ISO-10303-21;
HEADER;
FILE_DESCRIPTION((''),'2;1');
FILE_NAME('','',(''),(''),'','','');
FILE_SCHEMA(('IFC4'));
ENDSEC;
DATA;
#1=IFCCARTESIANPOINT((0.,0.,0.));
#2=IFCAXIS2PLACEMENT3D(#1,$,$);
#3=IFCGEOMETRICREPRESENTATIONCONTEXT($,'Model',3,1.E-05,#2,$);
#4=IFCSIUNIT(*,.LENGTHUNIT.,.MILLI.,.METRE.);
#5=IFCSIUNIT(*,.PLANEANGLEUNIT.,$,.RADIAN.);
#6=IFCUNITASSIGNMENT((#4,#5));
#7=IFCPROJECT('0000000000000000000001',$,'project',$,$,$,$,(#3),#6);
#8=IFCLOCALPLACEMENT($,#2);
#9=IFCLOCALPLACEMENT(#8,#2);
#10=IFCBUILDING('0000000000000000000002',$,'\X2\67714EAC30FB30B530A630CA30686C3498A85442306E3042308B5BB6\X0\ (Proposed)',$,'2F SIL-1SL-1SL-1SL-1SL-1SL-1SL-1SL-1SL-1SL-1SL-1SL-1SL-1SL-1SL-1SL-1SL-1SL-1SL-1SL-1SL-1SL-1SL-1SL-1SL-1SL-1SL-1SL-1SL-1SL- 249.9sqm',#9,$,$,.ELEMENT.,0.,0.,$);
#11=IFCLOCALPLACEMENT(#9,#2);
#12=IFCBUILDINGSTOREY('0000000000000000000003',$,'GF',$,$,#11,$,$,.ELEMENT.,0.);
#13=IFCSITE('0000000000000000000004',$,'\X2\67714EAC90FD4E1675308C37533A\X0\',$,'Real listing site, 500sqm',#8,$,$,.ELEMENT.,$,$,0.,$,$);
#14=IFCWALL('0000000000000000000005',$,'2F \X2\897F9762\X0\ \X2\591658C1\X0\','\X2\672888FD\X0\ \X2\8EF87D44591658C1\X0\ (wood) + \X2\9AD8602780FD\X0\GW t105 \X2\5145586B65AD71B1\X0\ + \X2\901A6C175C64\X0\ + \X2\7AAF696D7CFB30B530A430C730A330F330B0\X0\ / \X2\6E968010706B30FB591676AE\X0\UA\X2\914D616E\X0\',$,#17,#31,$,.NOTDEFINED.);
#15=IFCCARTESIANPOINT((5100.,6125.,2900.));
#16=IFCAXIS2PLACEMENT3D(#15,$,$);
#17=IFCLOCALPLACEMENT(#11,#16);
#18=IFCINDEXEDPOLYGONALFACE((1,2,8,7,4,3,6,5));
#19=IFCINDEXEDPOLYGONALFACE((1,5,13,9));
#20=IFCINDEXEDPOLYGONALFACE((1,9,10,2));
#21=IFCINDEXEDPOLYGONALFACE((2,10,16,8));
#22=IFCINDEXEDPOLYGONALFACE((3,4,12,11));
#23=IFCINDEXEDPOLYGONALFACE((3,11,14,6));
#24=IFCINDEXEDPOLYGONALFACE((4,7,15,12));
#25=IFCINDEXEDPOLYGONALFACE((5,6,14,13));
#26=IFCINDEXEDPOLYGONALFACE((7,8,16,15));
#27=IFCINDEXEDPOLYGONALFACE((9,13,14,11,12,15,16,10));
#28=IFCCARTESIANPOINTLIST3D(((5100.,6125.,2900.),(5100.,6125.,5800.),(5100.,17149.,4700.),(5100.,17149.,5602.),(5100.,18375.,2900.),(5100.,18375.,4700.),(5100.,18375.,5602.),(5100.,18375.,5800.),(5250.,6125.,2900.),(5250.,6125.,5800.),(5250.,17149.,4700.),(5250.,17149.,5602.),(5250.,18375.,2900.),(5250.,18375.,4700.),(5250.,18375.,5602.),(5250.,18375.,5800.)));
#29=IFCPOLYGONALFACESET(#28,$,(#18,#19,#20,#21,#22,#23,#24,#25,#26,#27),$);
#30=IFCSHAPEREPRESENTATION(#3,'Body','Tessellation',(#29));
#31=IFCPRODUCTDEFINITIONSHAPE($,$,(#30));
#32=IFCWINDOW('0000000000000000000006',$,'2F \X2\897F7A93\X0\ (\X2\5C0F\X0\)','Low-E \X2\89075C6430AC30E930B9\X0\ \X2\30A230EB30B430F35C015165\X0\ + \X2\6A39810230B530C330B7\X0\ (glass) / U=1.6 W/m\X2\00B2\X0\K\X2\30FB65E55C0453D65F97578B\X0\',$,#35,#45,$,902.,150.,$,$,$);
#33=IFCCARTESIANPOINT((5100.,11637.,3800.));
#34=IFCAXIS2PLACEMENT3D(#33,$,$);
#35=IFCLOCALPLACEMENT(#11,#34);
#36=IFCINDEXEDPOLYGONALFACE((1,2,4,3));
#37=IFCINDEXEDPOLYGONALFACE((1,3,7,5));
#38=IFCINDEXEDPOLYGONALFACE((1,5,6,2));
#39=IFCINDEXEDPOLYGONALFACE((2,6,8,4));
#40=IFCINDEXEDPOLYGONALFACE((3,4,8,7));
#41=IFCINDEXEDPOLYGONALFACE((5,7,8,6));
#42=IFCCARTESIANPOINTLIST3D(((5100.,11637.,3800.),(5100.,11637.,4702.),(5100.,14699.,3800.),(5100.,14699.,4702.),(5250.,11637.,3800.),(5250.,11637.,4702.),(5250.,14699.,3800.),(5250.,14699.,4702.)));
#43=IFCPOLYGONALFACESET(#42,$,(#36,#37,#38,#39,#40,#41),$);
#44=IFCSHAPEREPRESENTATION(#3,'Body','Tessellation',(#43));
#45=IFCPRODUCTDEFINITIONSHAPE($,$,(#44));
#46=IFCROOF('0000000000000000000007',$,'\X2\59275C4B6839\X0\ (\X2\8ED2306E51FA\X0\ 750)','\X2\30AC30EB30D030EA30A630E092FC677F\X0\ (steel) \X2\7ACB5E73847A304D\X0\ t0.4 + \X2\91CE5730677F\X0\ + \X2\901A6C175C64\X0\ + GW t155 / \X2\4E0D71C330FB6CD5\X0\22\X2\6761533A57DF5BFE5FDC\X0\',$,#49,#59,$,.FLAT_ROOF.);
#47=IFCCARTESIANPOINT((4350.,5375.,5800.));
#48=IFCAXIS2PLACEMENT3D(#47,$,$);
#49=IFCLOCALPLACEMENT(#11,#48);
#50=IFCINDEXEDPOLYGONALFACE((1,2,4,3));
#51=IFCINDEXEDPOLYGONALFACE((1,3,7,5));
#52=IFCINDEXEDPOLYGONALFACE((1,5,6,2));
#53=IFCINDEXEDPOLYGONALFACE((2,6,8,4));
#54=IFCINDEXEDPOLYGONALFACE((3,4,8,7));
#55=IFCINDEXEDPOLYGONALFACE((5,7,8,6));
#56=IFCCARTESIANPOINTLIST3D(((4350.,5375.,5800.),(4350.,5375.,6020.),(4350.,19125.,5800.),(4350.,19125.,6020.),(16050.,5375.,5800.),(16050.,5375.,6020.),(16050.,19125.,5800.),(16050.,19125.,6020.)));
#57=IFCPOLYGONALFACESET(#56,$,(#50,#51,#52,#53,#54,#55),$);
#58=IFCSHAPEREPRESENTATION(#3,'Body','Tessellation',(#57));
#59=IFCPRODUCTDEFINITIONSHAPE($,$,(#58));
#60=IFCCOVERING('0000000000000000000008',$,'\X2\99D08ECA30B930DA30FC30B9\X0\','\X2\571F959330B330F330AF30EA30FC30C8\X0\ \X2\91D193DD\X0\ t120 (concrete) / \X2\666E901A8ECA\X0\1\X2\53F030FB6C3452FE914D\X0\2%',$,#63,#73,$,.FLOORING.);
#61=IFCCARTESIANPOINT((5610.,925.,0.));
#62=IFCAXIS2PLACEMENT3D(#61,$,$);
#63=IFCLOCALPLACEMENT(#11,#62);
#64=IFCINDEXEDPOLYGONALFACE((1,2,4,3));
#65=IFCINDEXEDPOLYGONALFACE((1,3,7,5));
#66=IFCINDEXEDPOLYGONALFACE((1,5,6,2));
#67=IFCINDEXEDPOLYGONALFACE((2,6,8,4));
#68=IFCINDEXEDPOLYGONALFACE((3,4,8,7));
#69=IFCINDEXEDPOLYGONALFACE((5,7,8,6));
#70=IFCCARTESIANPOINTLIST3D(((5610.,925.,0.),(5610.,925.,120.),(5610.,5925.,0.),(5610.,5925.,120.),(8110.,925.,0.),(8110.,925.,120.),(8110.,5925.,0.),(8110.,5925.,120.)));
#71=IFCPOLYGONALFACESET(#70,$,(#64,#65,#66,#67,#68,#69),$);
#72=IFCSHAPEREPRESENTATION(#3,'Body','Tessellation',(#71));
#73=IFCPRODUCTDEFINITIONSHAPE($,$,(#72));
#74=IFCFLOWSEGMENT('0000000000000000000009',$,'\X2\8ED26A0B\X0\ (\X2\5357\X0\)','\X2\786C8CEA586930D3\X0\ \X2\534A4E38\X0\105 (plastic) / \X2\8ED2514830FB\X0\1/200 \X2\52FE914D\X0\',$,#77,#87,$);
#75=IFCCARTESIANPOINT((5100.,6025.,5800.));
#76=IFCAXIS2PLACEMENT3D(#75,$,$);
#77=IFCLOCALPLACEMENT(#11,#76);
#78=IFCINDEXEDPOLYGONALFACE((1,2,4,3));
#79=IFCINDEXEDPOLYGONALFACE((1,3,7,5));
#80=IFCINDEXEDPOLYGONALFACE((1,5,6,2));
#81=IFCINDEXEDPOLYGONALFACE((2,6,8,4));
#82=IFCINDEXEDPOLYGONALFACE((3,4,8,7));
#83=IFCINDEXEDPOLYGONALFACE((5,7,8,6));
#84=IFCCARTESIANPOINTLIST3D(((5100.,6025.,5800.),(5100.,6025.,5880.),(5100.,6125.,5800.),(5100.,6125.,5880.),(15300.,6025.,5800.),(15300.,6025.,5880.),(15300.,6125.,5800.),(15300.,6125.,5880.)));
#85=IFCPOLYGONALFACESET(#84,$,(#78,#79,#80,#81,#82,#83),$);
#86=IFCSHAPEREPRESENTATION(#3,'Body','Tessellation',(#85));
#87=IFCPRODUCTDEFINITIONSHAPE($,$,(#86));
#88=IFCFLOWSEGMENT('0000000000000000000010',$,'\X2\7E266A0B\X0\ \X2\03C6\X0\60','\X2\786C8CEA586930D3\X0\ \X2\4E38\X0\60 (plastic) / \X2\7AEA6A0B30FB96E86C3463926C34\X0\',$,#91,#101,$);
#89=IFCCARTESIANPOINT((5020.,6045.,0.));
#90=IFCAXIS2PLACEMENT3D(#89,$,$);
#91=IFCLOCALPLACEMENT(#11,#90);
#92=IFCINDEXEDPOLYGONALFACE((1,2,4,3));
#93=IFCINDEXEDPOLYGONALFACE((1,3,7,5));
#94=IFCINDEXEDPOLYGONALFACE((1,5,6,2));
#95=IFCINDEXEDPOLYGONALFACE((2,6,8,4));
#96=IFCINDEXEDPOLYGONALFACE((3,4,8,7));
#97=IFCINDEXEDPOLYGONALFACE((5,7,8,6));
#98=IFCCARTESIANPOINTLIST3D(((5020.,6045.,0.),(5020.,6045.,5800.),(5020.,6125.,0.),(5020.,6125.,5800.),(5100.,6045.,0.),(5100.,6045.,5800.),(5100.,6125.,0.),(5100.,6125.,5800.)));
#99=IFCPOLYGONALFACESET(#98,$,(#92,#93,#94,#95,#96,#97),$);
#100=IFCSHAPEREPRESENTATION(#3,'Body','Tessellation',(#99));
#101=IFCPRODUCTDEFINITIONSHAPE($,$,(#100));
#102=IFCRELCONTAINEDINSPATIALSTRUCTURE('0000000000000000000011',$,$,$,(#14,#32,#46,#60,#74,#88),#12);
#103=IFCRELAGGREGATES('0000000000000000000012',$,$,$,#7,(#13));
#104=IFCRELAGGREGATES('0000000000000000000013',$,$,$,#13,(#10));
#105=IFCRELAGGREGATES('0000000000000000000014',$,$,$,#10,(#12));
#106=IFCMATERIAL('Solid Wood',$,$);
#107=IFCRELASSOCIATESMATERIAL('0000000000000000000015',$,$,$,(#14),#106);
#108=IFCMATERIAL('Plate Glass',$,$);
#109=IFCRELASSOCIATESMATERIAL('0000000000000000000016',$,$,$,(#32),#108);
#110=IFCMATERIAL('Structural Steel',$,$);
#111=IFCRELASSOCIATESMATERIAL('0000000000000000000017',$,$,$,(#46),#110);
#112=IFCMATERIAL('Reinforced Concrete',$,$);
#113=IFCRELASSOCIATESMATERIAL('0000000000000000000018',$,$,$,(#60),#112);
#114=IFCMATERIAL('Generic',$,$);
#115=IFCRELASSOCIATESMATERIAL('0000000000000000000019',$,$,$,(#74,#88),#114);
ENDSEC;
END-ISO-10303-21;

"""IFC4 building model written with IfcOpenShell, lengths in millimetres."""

from ifc_helpers import new_model, si_unit, frame, frame_2d, origin, place, context, project, spatial, rectangle, extrude, material, element, fill, save


model = new_model("IFC4")

# Units and contexts
model_context = context("Model", 3, precision=1e-05, world=origin())
ifc_project = project(units=[si_unit("LENGTHUNIT", "METRE", prefix="MILLI"), si_unit("PLANEANGLEUNIT", "RADIAN")], contexts=[model_context])

# Site, building, storey
site_placement = place(None, origin())
site = spatial("IfcSite", under=ifc_project, at=site_placement, Name="東京都世田谷区", ObjectType="Real listing site, 500sqm", CompositionType="ELEMENT", RefElevation=0.0)
building_placement = place(site_placement, origin())
building = spatial("IfcBuilding", under=site, at=building_placement, Name="東京・サウナと水風呂のある家 (Proposed)", ObjectType="2F SIL-1SL-1SL-1SL-1SL-1SL-1SL-1SL-1SL-1SL-1SL-1SL-1SL-1SL-1SL-1SL-1SL-1SL-1SL-1SL-1SL-1SL-1SL-1SL-1SL-1SL-1SL-1SL-1SL-1SL- 249.9sqm", CompositionType="ELEMENT", ElevationOfRefHeight=0.0, ElevationOfTerrain=0.0)
storey_placement = place(building_placement, origin())
storey = spatial("IfcBuildingStorey", under=building, at=storey_placement, Name="GF", CompositionType="ELEMENT", Elevation=0.0)

# Shared definitions
ifc_material_1 = material(Name="Solid Wood")

# Shared definitions
ifc_material_2 = material(Name="Reinforced Concrete")

# Shared definitions
ifc_material_3 = material(Name="Plate Glass")

# Wall, opening, window
wall_1_placement = place(storey_placement, frame((5100.0, 6125.0, 2900.0)))
wall_1 = element("IfcWall", 1, at=wall_1_placement, inside=storey, material=ifc_material_1, Name="2F 西面 外壁", Description="木製 軸組外壁 (wood) + 高性能GW t105 充填断熱 + 通気層 + 窯業系サイディング / 準耐火・外皮UA配慮", PredefinedType="NOTDEFINED", context=model_context, shape_type="SweptSolid", body=[
    extrude(rectangle(XDim=150.0, YDim=12250.0, at=frame_2d((75.0, 6125.0))), frame((5100.0, 6125.0, 2900.0)), (0.0, 0.0, 1.0), 2900.0),
])
opening_1_placement = place(storey_placement, frame((5100.0, 11637.0, 3800.0)))
opening_1 = element("IfcOpeningElement", 2, at=opening_1_placement, cuts=wall_1, PredefinedType="NOTDEFINED", context=model_context, shape_type="SweptSolid", body=[
    extrude(rectangle(XDim=150.0, YDim=3062.0, at=frame_2d((75.0, 1531.0))), frame((5100.0, 11637.0, 3800.0)), (0.0, 0.0, 1.0), 902.0),
])
window_1_placement = place(storey_placement, frame((5100.0, 11637.0, 3800.0)))
window_1 = element("IfcWindow", 3, at=window_1_placement, inside=storey, material=ifc_material_3, Name="2F 西窓 (小)", Description="Low-E 複層ガラス アルゴン封入 + 樹脂サッシ (glass) / U=1.6 W/m²K・日射取得型", OverallHeight=902.0, OverallWidth=150.0, context=model_context, shape_type="SweptSolid", body=[
    extrude(rectangle(XDim=150.0, YDim=3062.0, at=frame_2d((75.0, 1531.0))), frame((5100.0, 11637.0, 3800.0)), (0.0, 0.0, 1.0), 902.0),
])
fill(opening_1, window_1)

# Roof
ifc_material_4 = material(Name="Structural Steel")
roof_placement = place(storey_placement, frame((4350.0, 5375.0, 5800.0)))
element("IfcRoof", 4, at=roof_placement, inside=storey, material=ifc_material_4, Name="大屋根 (軒の出 750)", Description="ガルバリウム鋼板 (steel) 立平葺き t0.4 + 野地板 + 通気層 + GW t155 / 不燃・法22条区域対応", PredefinedType="FLAT_ROOF", context=model_context, shape_type="SweptSolid", body=[
    extrude(rectangle(XDim=11700.0, YDim=13750.0, at=frame_2d((5850.0, 6875.0))), frame((4350.0, 5375.0, 5800.0)), (0.0, 0.0, 1.0), 220.0),
])

# Covering
covering_placement = place(storey_placement, frame((5610.0, 925.0, 0.0)))
element("IfcCovering", 5, at=covering_placement, inside=storey, material=ifc_material_2, Name="駐車スペース", Description="土間コンクリート 金鏝 t120 (concrete) / 普通車1台・水勾配2%", PredefinedType="FLOORING", context=model_context, shape_type="SweptSolid", body=[
    extrude(rectangle(XDim=2500.0, YDim=5000.0, at=frame_2d((1250.0, 2500.0))), frame((5610.0, 925.0, 0.0)), (0.0, 0.0, 1.0), 120.0),
])

# Flow segments
ifc_material_5 = material(Name="Generic")
flow_segment_1_placement = place(storey_placement, frame((5100.0, 6025.0, 5800.0)))
element("IfcFlowSegment", 6, at=flow_segment_1_placement, inside=storey, material=ifc_material_5, Name="軒樋 (南)", Description="硬質塩ビ 半丸105 (plastic) / 軒先・1/200 勾配", context=model_context, shape_type="SweptSolid", body=[
    extrude(rectangle(XDim=10200.0, YDim=100.0, at=frame_2d((5100.0, 50.0))), frame((5100.0, 6025.0, 5800.0)), (0.0, 0.0, 1.0), 80.0),
])
flow_segment_2_placement = place(storey_placement, frame((5020.0, 6045.0, 0.0)))
element("IfcFlowSegment", 7, at=flow_segment_2_placement, inside=storey, material=ifc_material_5, Name="縦樋 φ60", Description="硬質塩ビ 丸60 (plastic) / 竪樋・雨水排水", context=model_context, shape_type="SweptSolid", body=[
    extrude(rectangle(XDim=80.0, YDim=80.0, at=frame_2d((40.0, 40.0))), frame((5020.0, 6045.0, 0.0)), (0.0, 0.0, 1.0), 5800.0),
])

save(model, "model.ifc")
